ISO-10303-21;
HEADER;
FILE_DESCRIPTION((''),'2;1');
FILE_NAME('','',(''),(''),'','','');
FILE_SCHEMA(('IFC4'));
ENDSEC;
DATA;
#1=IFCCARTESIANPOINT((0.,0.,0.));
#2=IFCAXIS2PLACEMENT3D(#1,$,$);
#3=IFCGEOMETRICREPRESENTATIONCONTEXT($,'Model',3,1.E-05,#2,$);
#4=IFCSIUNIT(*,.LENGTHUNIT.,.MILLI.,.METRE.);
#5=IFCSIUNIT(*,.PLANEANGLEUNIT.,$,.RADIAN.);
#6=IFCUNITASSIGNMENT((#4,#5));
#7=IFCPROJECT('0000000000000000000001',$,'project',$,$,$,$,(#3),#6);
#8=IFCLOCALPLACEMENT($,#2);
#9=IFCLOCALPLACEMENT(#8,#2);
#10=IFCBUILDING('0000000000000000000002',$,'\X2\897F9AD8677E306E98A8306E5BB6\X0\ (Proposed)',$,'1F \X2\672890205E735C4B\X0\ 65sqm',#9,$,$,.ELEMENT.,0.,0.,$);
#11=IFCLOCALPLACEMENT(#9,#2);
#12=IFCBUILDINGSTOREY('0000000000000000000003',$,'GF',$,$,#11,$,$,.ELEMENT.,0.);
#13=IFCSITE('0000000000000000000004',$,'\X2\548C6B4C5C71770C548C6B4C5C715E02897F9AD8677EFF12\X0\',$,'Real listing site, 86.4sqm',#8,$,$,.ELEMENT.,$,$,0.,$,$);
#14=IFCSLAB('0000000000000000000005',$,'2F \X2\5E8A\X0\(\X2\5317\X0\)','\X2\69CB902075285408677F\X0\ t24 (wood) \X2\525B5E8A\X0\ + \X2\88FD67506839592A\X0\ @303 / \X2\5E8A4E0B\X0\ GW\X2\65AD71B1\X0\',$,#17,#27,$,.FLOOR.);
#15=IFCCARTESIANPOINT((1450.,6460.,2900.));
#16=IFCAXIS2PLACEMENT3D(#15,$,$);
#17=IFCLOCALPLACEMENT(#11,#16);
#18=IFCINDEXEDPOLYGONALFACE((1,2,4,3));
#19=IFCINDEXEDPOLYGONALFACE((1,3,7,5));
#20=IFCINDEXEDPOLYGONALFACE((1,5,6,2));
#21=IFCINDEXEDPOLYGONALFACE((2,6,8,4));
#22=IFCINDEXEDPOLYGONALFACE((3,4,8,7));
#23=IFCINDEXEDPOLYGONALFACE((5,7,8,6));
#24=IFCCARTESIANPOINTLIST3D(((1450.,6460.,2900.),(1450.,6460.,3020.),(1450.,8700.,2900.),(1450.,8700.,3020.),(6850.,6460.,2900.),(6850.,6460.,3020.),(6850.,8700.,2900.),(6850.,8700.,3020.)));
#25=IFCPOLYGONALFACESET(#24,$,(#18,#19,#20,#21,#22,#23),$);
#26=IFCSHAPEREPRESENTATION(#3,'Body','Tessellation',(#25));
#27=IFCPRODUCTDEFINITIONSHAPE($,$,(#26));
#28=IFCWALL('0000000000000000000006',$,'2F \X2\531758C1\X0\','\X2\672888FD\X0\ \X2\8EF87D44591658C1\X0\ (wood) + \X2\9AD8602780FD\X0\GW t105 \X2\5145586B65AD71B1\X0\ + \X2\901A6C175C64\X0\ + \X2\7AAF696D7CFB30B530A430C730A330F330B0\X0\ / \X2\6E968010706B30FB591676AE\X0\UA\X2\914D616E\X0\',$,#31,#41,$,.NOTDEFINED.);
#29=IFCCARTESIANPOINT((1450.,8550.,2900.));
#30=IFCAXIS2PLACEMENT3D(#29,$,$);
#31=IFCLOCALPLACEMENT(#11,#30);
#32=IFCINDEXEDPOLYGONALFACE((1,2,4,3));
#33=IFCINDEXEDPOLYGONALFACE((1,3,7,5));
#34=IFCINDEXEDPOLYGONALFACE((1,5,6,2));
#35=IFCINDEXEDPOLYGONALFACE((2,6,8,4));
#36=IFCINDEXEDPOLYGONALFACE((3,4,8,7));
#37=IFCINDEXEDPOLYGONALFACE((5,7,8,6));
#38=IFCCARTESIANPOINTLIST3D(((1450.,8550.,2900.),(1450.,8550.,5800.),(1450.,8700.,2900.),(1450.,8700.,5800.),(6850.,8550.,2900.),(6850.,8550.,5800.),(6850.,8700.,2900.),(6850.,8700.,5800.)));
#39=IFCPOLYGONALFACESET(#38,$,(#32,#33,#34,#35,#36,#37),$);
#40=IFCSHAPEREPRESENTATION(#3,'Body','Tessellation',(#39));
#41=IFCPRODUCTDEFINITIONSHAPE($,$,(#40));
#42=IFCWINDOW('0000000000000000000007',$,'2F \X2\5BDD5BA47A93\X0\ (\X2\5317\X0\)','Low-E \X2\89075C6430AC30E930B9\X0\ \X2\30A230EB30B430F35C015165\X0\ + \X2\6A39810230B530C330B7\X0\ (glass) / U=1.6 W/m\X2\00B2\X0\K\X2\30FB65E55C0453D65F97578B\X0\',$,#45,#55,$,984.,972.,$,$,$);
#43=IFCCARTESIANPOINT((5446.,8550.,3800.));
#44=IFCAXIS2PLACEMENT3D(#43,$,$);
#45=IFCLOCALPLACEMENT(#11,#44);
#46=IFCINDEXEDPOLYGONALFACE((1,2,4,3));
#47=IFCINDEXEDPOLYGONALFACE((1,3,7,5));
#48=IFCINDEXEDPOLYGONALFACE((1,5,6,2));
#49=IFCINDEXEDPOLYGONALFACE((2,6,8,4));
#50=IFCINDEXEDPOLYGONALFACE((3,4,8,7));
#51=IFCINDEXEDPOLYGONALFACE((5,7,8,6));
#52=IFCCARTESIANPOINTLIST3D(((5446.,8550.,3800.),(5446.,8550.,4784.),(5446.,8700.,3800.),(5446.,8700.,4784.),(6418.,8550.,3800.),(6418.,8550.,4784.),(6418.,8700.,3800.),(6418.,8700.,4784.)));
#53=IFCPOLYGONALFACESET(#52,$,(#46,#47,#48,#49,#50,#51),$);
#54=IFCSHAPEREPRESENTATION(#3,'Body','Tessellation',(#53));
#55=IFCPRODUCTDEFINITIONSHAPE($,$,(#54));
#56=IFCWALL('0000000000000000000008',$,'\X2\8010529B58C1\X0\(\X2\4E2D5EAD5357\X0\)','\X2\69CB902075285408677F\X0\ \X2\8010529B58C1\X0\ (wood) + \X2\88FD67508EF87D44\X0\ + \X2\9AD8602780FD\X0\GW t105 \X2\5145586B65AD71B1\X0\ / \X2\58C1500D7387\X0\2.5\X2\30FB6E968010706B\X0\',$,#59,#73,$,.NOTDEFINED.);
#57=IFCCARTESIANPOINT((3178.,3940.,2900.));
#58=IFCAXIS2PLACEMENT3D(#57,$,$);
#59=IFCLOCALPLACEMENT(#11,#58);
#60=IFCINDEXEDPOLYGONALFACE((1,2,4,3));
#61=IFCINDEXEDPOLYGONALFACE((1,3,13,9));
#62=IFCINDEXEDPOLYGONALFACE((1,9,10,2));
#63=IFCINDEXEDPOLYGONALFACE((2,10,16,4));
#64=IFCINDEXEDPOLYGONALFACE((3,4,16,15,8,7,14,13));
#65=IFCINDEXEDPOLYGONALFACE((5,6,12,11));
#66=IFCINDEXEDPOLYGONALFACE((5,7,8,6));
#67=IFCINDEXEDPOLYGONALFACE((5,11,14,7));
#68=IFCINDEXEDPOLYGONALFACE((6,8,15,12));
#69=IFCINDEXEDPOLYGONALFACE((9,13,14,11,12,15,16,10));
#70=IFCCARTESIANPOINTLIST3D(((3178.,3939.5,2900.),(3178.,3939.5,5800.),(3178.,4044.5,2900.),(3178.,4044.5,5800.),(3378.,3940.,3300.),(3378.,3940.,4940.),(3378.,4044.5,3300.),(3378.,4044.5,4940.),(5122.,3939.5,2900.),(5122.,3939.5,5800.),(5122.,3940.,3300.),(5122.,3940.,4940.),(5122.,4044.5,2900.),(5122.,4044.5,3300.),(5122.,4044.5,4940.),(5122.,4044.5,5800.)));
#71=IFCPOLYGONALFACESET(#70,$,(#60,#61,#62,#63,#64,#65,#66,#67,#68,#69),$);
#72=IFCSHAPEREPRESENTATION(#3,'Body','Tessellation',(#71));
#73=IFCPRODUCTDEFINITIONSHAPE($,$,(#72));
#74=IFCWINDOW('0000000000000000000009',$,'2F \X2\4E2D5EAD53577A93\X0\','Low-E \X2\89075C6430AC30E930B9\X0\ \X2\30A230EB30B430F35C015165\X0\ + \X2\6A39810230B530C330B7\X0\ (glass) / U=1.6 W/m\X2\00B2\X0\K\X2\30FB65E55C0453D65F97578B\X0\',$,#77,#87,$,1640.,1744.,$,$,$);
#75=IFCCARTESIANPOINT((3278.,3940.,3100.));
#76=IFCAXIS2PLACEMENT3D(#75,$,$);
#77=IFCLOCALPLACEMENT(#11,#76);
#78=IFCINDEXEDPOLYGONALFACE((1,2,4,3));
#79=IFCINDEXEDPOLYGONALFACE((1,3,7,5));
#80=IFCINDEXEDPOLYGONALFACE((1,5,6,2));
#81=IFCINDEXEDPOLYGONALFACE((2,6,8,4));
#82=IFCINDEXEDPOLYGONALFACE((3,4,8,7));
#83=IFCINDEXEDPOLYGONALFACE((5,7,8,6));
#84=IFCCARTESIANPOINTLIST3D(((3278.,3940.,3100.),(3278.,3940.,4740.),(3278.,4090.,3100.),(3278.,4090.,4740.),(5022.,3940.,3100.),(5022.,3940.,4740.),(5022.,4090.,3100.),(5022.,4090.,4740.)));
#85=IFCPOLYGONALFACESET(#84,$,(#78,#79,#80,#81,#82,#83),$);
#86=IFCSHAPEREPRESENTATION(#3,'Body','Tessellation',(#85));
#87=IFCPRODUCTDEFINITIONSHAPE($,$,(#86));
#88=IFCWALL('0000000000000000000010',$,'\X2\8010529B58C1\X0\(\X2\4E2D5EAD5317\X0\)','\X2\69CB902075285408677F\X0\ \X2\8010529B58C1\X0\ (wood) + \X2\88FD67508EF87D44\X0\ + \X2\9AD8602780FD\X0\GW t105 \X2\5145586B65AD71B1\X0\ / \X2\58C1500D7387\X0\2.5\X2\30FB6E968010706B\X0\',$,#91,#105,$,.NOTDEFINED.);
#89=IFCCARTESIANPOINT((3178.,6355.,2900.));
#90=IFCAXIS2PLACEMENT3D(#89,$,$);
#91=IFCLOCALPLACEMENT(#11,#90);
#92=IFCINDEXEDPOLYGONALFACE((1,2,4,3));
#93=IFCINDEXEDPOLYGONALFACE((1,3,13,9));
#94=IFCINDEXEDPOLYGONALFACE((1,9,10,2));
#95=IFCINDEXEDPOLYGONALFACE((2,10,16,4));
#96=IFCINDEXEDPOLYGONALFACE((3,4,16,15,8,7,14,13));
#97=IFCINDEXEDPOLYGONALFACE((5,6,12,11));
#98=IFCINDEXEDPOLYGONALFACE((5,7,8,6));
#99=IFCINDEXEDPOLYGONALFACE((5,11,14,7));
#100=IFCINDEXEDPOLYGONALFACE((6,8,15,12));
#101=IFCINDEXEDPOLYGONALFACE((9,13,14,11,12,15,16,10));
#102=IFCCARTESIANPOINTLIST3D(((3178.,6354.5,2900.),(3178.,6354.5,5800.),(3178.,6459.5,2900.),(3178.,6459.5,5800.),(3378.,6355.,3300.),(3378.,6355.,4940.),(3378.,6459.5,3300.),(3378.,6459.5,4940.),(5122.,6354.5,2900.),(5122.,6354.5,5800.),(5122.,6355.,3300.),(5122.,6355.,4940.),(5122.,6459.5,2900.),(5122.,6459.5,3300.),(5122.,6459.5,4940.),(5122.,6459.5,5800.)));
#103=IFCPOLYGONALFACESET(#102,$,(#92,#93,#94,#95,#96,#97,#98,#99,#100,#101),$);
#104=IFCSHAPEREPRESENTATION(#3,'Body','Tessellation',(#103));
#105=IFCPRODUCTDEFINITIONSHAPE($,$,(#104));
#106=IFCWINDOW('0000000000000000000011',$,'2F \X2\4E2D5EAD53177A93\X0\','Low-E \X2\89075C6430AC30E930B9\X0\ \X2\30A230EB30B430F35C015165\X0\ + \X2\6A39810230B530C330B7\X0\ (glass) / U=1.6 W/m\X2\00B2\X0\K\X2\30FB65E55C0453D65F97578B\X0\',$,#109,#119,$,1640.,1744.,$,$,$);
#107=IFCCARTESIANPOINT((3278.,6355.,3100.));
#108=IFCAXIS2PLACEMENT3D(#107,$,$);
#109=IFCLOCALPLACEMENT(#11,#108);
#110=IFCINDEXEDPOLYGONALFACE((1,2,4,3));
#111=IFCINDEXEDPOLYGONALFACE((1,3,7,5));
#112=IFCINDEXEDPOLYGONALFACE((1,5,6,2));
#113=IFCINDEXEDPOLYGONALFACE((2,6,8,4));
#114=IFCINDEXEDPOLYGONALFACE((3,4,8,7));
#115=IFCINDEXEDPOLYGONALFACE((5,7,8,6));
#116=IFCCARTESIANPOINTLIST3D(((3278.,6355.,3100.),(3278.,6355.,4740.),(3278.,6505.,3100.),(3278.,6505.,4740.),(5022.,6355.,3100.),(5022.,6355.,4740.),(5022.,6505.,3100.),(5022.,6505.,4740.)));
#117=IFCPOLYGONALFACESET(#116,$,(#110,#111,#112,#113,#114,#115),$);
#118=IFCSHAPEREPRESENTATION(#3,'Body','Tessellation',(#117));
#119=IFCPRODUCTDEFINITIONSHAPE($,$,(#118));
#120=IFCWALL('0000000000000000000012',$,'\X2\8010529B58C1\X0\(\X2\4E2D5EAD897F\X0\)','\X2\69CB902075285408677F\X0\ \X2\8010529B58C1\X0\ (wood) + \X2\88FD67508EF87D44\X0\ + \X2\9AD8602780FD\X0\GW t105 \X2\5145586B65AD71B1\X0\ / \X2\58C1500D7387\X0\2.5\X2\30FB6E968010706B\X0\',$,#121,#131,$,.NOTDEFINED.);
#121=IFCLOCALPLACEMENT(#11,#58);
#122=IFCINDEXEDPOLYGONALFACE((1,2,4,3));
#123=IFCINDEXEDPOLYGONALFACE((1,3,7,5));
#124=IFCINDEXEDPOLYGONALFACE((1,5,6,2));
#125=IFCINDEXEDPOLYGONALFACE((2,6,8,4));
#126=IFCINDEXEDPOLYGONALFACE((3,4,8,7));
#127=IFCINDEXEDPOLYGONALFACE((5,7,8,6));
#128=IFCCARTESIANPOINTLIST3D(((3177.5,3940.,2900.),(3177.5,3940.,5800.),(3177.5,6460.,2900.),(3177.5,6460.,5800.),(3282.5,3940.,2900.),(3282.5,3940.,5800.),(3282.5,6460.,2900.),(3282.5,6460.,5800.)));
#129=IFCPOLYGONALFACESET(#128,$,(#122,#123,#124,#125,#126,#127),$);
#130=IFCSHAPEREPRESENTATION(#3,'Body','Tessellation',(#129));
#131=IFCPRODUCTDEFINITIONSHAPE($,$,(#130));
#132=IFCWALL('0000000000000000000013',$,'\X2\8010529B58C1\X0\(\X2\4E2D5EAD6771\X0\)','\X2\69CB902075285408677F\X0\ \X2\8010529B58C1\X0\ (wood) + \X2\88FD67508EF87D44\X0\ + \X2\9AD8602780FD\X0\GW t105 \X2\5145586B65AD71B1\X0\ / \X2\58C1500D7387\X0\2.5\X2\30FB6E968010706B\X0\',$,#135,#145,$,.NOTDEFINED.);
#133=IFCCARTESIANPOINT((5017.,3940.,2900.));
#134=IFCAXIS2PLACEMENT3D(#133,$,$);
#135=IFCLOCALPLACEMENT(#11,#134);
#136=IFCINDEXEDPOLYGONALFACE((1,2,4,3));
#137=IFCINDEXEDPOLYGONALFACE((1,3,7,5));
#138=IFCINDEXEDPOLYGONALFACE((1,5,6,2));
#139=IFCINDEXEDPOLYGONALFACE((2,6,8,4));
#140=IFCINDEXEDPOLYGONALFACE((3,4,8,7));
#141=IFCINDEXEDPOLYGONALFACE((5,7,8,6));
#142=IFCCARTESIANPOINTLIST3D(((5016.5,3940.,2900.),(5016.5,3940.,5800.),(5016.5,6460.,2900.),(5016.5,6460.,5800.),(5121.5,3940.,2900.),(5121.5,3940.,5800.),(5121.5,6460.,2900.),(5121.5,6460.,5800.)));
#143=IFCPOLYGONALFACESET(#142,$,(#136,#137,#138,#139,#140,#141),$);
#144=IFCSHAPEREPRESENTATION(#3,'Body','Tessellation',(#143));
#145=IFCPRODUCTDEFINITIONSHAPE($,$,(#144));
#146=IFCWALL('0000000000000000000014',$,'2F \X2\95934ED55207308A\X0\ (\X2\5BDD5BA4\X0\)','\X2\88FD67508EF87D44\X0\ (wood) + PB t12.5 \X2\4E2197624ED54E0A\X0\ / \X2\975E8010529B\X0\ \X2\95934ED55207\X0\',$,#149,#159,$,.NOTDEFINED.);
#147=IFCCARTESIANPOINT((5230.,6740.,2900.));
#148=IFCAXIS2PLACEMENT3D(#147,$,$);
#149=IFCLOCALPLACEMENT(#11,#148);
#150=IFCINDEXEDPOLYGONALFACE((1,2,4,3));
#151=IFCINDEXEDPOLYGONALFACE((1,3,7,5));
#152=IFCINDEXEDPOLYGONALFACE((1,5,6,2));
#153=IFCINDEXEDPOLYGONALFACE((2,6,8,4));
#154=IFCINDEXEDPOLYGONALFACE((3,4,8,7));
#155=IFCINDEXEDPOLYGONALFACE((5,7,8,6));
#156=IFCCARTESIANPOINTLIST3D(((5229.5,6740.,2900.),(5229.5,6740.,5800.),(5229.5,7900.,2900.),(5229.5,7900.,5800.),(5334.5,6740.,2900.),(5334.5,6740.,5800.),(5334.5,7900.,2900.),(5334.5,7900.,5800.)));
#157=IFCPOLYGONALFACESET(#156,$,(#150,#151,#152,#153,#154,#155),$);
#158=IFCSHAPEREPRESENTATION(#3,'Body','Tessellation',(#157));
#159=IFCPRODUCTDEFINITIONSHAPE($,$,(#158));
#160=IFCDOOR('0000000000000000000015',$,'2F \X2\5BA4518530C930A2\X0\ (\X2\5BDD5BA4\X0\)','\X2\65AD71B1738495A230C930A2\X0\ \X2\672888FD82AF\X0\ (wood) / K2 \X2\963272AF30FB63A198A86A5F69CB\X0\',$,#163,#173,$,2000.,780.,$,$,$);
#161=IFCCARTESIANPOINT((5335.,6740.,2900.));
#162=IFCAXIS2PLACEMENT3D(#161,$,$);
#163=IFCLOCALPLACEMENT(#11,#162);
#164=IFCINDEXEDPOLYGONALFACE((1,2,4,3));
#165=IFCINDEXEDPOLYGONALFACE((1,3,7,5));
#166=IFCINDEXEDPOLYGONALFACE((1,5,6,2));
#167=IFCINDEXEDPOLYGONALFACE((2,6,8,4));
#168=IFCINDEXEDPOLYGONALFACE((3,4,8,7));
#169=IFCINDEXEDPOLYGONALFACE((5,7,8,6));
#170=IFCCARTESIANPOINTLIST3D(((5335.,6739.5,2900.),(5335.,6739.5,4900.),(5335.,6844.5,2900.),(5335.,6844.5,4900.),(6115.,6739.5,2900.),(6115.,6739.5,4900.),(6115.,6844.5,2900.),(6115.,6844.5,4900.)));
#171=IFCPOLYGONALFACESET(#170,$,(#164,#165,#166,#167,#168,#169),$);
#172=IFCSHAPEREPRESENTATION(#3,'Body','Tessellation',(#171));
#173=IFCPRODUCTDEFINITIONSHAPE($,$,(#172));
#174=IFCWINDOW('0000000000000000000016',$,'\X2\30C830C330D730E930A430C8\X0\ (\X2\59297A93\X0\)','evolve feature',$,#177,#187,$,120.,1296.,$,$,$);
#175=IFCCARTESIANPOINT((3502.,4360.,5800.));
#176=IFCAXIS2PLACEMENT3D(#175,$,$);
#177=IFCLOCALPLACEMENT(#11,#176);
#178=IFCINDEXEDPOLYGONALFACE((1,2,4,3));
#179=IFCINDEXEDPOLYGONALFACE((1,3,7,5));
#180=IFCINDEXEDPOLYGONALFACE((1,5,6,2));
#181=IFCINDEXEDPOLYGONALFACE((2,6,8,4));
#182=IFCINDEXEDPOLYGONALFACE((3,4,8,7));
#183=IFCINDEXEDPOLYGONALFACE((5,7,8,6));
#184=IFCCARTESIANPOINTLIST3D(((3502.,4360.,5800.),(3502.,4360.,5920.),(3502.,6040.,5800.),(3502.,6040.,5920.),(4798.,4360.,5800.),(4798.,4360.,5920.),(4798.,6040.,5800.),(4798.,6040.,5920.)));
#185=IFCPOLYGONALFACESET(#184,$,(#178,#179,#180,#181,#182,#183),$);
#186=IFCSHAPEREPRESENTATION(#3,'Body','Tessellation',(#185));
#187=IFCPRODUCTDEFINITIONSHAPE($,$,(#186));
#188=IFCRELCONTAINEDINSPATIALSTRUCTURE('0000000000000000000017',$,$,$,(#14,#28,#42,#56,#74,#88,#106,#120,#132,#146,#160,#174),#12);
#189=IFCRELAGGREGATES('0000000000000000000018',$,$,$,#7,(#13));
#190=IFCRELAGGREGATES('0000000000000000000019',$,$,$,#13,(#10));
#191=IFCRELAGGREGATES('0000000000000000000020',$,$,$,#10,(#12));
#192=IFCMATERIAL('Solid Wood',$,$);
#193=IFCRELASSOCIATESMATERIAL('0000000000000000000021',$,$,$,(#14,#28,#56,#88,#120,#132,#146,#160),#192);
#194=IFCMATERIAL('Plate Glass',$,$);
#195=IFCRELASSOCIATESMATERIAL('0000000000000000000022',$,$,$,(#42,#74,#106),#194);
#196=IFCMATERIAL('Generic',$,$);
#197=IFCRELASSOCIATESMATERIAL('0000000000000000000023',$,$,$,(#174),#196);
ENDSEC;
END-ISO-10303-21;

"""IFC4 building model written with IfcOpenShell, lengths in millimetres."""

from ifc_helpers import new_model, si_unit, frame, frame_2d, origin, place, context, project, spatial, rectangle, extrude, material, element, fill, save


model = new_model("IFC4")

# Units and contexts
model_context = context("Model", 3, precision=1e-05, world=origin())
ifc_project = project(units=[si_unit("LENGTHUNIT", "METRE", prefix="MILLI"), si_unit("PLANEANGLEUNIT", "RADIAN")], contexts=[model_context])

# Site, building, storey
site_placement = place(None, origin())
site = spatial("IfcSite", under=ifc_project, at=site_placement, Name="和歌山県和歌山市西高松２", ObjectType="Real listing site, 86.4sqm", CompositionType="ELEMENT", RefElevation=0.0)
building_placement = place(site_placement, origin())
building = spatial("IfcBuilding", under=site, at=building_placement, Name="西高松の風の家 (Proposed)", ObjectType="1F 木造平屋 65sqm", CompositionType="ELEMENT", ElevationOfRefHeight=0.0, ElevationOfTerrain=0.0)
storey_placement = place(building_placement, origin())
storey = spatial("IfcBuildingStorey", under=building, at=storey_placement, Name="GF", CompositionType="ELEMENT", Elevation=0.0)

# Slab
ifc_material_1 = material(Name="Solid Wood")
slab_placement = place(storey_placement, frame((1450.0, 6460.0, 2900.0)))
element("IfcSlab", 1, at=slab_placement, inside=storey, material=ifc_material_1, Name="2F 床(北)", Description="構造用合板 t24 (wood) 剛床 + 製材根太 @303 / 床下 GW断熱", PredefinedType="FLOOR", context=model_context, shape_type="SweptSolid", body=[
    extrude(rectangle(XDim=5400.0, YDim=2240.0, at=frame_2d((2700.0, 1120.0))), frame((1450.0, 6460.0, 2900.0)), (0.0, 0.0, 1.0), 120.0),
])

# Walls, openings, windows
wall_1_placement = place(storey_placement, frame((1450.0, 8550.0, 2900.0)))
wall_1 = element("IfcWall", 2, at=wall_1_placement, inside=storey, material=ifc_material_1, Name="2F 北壁", Description="木製 軸組外壁 (wood) + 高性能GW t105 充填断熱 + 通気層 + 窯業系サイディング / 準耐火・外皮UA配慮", PredefinedType="NOTDEFINED", context=model_context, shape_type="SweptSolid", body=[
    extrude(rectangle(XDim=5400.0, YDim=150.0, at=frame_2d((2700.0, 75.0))), frame((1450.0, 8550.0, 2900.0)), (0.0, 0.0, 1.0), 2900.0),
])
opening_1_placement = place(storey_placement, frame((5446.0, 8550.0, 3800.0)))
opening_1 = element("IfcOpeningElement", 3, at=opening_1_placement, cuts=wall_1, PredefinedType="NOTDEFINED", context=model_context, shape_type="SweptSolid", body=[
    extrude(rectangle(XDim=972.0, YDim=150.0, at=frame_2d((486.0, 75.0))), frame((5446.0, 8550.0, 3800.0)), (0.0, 0.0, 1.0), 984.0),
])
ifc_material_2 = material(Name="Plate Glass")
window_1_placement = place(storey_placement, frame((5446.0, 8550.0, 3800.0)))
window_1 = element("IfcWindow", 4, at=window_1_placement, inside=storey, material=ifc_material_2, Name="2F 寝室窓 (北)", Description="Low-E 複層ガラス アルゴン封入 + 樹脂サッシ (glass) / U=1.6 W/m²K・日射取得型", OverallHeight=984.0, OverallWidth=972.0, context=model_context, shape_type="SweptSolid", body=[
    extrude(rectangle(XDim=972.0, YDim=150.0, at=frame_2d((486.0, 75.0))), frame((5446.0, 8550.0, 3800.0)), (0.0, 0.0, 1.0), 984.0),
])
fill(opening_1, window_1)
wall_2_placement = place(storey_placement, frame((3178.0, 3940.0, 2900.0)))
wall_2 = element("IfcWall", 5, at=wall_2_placement, inside=storey, material=ifc_material_1, Name="耐力壁(中庭南)", Description="構造用合板 耐力壁 (wood) + 製材軸組 + 高性能GW t105 充填断熱 / 壁倍率2.5・準耐火", PredefinedType="NOTDEFINED", context=model_context, shape_type="SweptSolid", body=[
    extrude(rectangle(XDim=1944.0, YDim=105.0, at=frame_2d((972.0, 52.0))), frame((3178.0, 3940.0, 2900.0)), (0.0, 0.0, 1.0), 2900.0),
])
opening_2_placement = place(storey_placement, frame((3278.0, 3940.0, 3100.0)))
opening_2 = element("IfcOpeningElement", 6, at=opening_2_placement, cuts=wall_2, PredefinedType="NOTDEFINED", context=model_context, shape_type="SweptSolid", body=[
    extrude(rectangle(XDim=1744.0, YDim=150.0, at=frame_2d((872.0, 75.0))), frame((3278.0, 3940.0, 3100.0)), (0.0, 0.0, 1.0), 1640.0),
])
window_2_placement = place(storey_placement, frame((3278.0, 3940.0, 3100.0)))
window_2 = element("IfcWindow", 7, at=window_2_placement, inside=storey, material=ifc_material_2, Name="2F 中庭南窓", Description="Low-E 複層ガラス アルゴン封入 + 樹脂サッシ (glass) / U=1.6 W/m²K・日射取得型", OverallHeight=1640.0, OverallWidth=1744.0, context=model_context, shape_type="SweptSolid", body=[
    extrude(rectangle(XDim=1744.0, YDim=150.0, at=frame_2d((872.0, 75.0))), frame((3278.0, 3940.0, 3100.0)), (0.0, 0.0, 1.0), 1640.0),
])
fill(opening_2, window_2)
wall_3_placement = place(storey_placement, frame((3178.0, 6355.0, 2900.0)))
wall_3 = element("IfcWall", 8, at=wall_3_placement, inside=storey, material=ifc_material_1, Name="耐力壁(中庭北)", Description="構造用合板 耐力壁 (wood) + 製材軸組 + 高性能GW t105 充填断熱 / 壁倍率2.5・準耐火", PredefinedType="NOTDEFINED", context=model_context, shape_type="SweptSolid", body=[
    extrude(rectangle(XDim=1944.0, YDim=105.0, at=frame_2d((972.0, 52.0))), frame((3178.0, 6355.0, 2900.0)), (0.0, 0.0, 1.0), 2900.0),
])
opening_3_placement = place(storey_placement, frame((3278.0, 6355.0, 3100.0)))
opening_3 = element("IfcOpeningElement", 9, at=opening_3_placement, cuts=wall_3, PredefinedType="NOTDEFINED", context=model_context, shape_type="SweptSolid", body=[
    extrude(rectangle(XDim=1744.0, YDim=150.0, at=frame_2d((872.0, 75.0))), frame((3278.0, 6355.0, 3100.0)), (0.0, 0.0, 1.0), 1640.0),
])
window_3_placement = place(storey_placement, frame((3278.0, 6355.0, 3100.0)))
window_3 = element("IfcWindow", 10, at=window_3_placement, inside=storey, material=ifc_material_2, Name="2F 中庭北窓", Description="Low-E 複層ガラス アルゴン封入 + 樹脂サッシ (glass) / U=1.6 W/m²K・日射取得型", OverallHeight=1640.0, OverallWidth=1744.0, context=model_context, shape_type="SweptSolid", body=[
    extrude(rectangle(XDim=1744.0, YDim=150.0, at=frame_2d((872.0, 75.0))), frame((3278.0, 6355.0, 3100.0)), (0.0, 0.0, 1.0), 1640.0),
])
fill(opening_3, window_3)

# Walls
wall_4_placement = place(storey_placement, frame((3178.0, 3940.0, 2900.0)))
element("IfcWall", 11, at=wall_4_placement, inside=storey, material=ifc_material_1, Name="耐力壁(中庭西)", Description="構造用合板 耐力壁 (wood) + 製材軸組 + 高性能GW t105 充填断熱 / 壁倍率2.5・準耐火", PredefinedType="NOTDEFINED", context=model_context, shape_type="SweptSolid", body=[
    extrude(rectangle(XDim=105.0, YDim=2520.0, at=frame_2d((52.0, 1260.0))), frame((3178.0, 3940.0, 2900.0)), (0.0, 0.0, 1.0), 2900.0),
])
wall_5_placement = place(storey_placement, frame((5017.0, 3940.0, 2900.0)))
element("IfcWall", 12, at=wall_5_placement, inside=storey, material=ifc_material_1, Name="耐力壁(中庭東)", Description="構造用合板 耐力壁 (wood) + 製材軸組 + 高性能GW t105 充填断熱 / 壁倍率2.5・準耐火", PredefinedType="NOTDEFINED", context=model_context, shape_type="SweptSolid", body=[
    extrude(rectangle(XDim=105.0, YDim=2520.0, at=frame_2d((52.0, 1260.0))), frame((5017.0, 3940.0, 2900.0)), (0.0, 0.0, 1.0), 2900.0),
])
wall_6_placement = place(storey_placement, frame((5230.0, 6740.0, 2900.0)))
element("IfcWall", 13, at=wall_6_placement, inside=storey, material=ifc_material_1, Name="2F 間仕切り (寝室)", Description="製材軸組 (wood) + PB t12.5 両面仕上 / 非耐力 間仕切", PredefinedType="NOTDEFINED", context=model_context, shape_type="SweptSolid", body=[
    extrude(rectangle(XDim=105.0, YDim=1160.0, at=frame_2d((52.0, 580.0))), frame((5230.0, 6740.0, 2900.0)), (0.0, 0.0, 1.0), 2900.0),
])

# Door
door_placement = place(storey_placement, frame((5335.0, 6740.0, 2900.0)))
element("IfcDoor", 14, at=door_placement, inside=storey, material=ifc_material_1, Name="2F 室内ドア (寝室)", Description="断熱玄関ドア 木製芯 (wood) / K2 防犯・採風機構", OverallHeight=2000.0, OverallWidth=780.0, context=model_context, shape_type="SweptSolid", body=[
    extrude(rectangle(XDim=780.0, YDim=105.0, at=frame_2d((390.0, 52.0))), frame((5335.0, 6740.0, 2900.0)), (0.0, 0.0, 1.0), 2000.0),
])

# Window
ifc_material_3 = material(Name="Generic")
window_4_placement = place(storey_placement, frame((3502.0, 4360.0, 5800.0)))
element("IfcWindow", 15, at=window_4_placement, inside=storey, material=ifc_material_3, Name="トップライト (天窓)", Description="evolve feature", OverallHeight=120.0, OverallWidth=1296.0, context=model_context, shape_type="SweptSolid", body=[
    extrude(rectangle(XDim=1296.0, YDim=1680.0, at=frame_2d((648.0, 840.0))), frame((3502.0, 4360.0, 5800.0)), (0.0, 0.0, 1.0), 120.0),
])

save(model, "model.ifc")
